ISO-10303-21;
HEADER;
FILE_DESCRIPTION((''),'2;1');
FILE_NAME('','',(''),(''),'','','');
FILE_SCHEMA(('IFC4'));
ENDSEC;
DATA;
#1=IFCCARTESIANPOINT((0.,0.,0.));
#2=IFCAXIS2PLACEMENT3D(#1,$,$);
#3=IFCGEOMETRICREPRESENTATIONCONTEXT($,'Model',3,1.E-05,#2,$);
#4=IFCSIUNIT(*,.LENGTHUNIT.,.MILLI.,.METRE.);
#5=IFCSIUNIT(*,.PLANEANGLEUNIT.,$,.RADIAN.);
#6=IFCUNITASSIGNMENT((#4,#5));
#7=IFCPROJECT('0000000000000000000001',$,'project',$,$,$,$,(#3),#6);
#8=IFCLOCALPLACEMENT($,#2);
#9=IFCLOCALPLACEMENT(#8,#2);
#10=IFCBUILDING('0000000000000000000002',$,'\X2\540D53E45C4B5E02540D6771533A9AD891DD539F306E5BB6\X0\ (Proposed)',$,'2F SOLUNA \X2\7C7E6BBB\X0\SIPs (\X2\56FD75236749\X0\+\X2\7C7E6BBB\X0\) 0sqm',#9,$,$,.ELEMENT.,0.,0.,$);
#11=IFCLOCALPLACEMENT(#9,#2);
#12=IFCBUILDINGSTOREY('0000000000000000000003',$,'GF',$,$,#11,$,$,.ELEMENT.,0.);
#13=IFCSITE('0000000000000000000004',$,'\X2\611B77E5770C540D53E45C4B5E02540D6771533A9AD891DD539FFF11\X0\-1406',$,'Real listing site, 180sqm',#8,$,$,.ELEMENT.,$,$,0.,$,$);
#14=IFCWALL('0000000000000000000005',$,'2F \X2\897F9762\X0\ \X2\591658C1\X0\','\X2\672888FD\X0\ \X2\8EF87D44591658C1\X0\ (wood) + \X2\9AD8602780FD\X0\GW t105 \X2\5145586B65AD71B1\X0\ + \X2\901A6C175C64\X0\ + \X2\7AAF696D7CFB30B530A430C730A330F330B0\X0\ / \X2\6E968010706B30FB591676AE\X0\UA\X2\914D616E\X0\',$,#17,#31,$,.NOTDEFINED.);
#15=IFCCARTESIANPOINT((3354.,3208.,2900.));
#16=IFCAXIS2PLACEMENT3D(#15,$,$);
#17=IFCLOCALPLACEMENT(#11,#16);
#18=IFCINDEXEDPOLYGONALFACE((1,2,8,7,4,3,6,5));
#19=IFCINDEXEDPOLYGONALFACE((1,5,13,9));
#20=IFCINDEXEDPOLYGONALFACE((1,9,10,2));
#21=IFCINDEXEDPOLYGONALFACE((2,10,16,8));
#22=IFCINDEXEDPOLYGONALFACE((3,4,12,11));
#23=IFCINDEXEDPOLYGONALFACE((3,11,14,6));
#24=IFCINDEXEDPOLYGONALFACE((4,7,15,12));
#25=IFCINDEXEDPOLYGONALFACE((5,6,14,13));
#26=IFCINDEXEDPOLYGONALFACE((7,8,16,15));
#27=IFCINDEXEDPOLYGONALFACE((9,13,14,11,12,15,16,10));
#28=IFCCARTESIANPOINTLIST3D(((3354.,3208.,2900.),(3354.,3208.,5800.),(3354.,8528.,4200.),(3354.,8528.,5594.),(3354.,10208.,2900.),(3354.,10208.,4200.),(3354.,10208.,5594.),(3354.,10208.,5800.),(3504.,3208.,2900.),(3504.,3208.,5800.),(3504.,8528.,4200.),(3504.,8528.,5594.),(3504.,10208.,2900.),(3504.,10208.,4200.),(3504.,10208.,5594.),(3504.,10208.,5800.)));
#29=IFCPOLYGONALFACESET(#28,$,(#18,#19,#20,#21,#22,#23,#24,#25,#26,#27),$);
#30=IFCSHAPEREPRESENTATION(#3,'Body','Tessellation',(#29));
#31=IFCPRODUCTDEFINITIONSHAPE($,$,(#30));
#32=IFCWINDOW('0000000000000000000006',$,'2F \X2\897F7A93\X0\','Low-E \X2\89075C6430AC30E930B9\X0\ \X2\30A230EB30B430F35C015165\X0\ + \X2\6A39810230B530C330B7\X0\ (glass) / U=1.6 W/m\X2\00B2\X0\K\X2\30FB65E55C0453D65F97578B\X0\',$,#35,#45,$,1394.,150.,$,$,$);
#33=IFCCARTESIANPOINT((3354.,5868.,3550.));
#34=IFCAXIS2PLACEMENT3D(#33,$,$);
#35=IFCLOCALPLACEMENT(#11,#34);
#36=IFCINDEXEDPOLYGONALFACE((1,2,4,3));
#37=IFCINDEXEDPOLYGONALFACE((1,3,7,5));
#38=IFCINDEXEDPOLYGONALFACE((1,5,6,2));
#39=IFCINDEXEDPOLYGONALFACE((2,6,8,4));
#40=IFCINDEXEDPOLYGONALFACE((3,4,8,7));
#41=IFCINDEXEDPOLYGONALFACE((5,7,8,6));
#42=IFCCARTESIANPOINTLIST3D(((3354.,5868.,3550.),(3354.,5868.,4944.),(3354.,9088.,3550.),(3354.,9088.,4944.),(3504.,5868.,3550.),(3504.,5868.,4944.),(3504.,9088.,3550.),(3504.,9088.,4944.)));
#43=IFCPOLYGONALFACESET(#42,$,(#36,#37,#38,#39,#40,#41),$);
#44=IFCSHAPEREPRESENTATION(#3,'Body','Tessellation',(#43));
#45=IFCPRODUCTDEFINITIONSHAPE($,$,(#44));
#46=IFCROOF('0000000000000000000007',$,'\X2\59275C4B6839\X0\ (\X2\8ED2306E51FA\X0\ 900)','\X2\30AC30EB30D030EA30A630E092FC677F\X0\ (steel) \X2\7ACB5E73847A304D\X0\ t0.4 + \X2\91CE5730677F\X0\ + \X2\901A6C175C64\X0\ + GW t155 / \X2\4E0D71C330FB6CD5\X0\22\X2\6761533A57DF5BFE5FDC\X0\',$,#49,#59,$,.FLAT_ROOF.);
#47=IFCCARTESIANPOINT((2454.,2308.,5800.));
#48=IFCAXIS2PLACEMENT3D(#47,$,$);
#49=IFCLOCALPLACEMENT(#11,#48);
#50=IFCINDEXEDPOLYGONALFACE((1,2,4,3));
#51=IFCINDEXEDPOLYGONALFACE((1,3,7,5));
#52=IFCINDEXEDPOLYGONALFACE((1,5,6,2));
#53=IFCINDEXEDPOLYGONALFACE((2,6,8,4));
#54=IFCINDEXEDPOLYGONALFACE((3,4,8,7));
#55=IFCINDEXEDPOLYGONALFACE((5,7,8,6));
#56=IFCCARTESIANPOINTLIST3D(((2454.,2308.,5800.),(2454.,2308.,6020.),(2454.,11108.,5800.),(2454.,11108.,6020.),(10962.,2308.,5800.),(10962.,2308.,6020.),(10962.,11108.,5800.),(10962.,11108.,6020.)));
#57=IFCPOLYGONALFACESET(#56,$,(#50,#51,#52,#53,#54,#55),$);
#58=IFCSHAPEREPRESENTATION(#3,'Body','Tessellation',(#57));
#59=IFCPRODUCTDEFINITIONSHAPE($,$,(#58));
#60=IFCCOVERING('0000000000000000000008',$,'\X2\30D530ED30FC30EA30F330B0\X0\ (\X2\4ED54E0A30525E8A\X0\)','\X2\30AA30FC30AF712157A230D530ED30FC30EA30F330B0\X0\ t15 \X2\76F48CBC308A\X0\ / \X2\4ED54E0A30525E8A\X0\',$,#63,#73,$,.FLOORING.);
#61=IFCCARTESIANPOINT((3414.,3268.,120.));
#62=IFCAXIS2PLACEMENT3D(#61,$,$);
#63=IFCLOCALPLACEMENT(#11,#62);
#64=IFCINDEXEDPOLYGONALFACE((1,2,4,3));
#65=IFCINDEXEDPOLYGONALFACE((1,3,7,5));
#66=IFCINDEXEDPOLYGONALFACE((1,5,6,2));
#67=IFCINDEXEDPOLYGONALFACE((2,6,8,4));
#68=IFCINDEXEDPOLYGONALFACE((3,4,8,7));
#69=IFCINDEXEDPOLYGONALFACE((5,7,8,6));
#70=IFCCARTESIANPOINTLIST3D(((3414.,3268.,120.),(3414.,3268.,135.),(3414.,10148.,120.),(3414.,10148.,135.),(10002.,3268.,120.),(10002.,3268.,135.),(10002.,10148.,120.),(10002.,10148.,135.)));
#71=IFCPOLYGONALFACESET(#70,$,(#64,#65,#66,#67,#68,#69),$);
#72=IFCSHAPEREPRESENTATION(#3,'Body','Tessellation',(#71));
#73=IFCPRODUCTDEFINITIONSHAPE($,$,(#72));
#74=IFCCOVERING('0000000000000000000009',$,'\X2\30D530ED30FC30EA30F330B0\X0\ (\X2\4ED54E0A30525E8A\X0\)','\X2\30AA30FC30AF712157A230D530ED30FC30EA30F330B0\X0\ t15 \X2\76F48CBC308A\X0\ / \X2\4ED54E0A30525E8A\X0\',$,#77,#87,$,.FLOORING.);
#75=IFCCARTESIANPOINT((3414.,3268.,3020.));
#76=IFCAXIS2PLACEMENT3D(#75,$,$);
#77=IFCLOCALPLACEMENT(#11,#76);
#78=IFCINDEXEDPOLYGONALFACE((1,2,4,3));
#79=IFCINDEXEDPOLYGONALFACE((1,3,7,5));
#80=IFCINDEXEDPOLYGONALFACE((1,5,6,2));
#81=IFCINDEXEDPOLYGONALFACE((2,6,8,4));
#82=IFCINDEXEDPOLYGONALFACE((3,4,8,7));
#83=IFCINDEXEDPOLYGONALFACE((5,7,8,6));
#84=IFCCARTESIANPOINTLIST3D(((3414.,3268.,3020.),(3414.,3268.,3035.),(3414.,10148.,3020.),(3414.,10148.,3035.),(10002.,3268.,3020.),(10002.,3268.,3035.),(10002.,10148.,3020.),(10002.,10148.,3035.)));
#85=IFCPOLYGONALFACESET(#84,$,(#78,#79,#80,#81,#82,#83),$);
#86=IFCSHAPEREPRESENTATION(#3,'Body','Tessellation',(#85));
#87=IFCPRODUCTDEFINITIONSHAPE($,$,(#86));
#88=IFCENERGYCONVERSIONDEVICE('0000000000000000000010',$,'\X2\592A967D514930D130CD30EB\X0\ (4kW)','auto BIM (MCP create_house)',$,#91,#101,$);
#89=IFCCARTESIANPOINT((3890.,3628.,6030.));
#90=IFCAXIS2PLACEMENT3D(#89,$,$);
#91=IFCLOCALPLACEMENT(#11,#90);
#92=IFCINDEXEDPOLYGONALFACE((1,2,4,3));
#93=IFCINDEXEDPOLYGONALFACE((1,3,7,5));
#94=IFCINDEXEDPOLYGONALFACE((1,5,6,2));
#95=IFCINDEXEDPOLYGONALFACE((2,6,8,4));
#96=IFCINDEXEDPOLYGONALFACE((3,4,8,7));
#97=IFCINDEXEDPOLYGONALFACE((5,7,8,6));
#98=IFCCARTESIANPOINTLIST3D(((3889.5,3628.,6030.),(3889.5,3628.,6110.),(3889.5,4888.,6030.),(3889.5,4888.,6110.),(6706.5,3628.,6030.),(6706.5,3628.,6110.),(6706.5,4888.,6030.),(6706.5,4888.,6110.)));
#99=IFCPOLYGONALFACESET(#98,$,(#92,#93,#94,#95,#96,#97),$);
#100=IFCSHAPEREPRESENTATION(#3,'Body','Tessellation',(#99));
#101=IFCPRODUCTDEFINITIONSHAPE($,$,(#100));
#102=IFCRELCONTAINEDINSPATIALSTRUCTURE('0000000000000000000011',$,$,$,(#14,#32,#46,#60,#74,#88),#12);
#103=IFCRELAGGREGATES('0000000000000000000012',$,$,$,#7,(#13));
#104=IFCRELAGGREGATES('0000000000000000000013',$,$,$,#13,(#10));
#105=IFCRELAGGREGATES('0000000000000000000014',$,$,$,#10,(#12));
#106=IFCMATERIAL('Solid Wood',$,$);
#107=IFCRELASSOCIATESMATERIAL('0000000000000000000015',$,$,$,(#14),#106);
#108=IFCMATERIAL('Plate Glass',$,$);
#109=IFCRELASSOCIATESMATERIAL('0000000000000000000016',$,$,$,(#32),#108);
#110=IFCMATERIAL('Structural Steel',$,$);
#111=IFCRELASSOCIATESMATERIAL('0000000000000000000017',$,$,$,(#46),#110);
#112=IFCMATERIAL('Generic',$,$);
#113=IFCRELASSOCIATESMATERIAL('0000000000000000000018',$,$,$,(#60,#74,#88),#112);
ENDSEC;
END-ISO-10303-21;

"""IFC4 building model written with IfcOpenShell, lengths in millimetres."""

from ifc_helpers import new_model, si_unit, frame, frame_2d, origin, place, context, project, spatial, rectangle, extrude, material, element, fill, save


model = new_model("IFC4")

# Units and contexts
model_context = context("Model", 3, precision=1e-05, world=origin())
ifc_project = project(units=[si_unit("LENGTHUNIT", "METRE", prefix="MILLI"), si_unit("PLANEANGLEUNIT", "RADIAN")], contexts=[model_context])

# Site, building, storey
site_placement = place(None, origin())
site = spatial("IfcSite", under=ifc_project, at=site_placement, Name="愛知県名古屋市名東区高針原１-1406", ObjectType="Real listing site, 180sqm", CompositionType="ELEMENT", RefElevation=0.0)
building_placement = place(site_placement, origin())
building = spatial("IfcBuilding", under=site, at=building_placement, Name="名古屋市名東区高針原の家 (Proposed)", ObjectType="2F SOLUNA 籾殻SIPs (国産杉+籾殻) 0sqm", CompositionType="ELEMENT", ElevationOfRefHeight=0.0, ElevationOfTerrain=0.0)
storey_placement = place(building_placement, origin())
storey = spatial("IfcBuildingStorey", under=building, at=storey_placement, Name="GF", CompositionType="ELEMENT", Elevation=0.0)

# Shared definitions
ifc_material_1 = material(Name="Solid Wood")

# Shared definitions
ifc_material_2 = material(Name="Plate Glass")

# Wall, opening, window
wall_1_placement = place(storey_placement, frame((3354.0, 3208.0, 2900.0)))
wall_1 = element("IfcWall", 1, at=wall_1_placement, inside=storey, material=ifc_material_1, Name="2F 西面 外壁", Description="木製 軸組外壁 (wood) + 高性能GW t105 充填断熱 + 通気層 + 窯業系サイディング / 準耐火・外皮UA配慮", PredefinedType="NOTDEFINED", context=model_context, shape_type="SweptSolid", body=[
    extrude(rectangle(XDim=150.0, YDim=7000.0, at=frame_2d((75.0, 3500.0))), frame((3354.0, 3208.0, 2900.0)), (0.0, 0.0, 1.0), 2900.0),
])
opening_1_placement = place(storey_placement, frame((3354.0, 5868.0, 3550.0)))
opening_1 = element("IfcOpeningElement", 2, at=opening_1_placement, cuts=wall_1, PredefinedType="NOTDEFINED", context=model_context, shape_type="SweptSolid", body=[
    extrude(rectangle(XDim=150.0, YDim=3220.0, at=frame_2d((75.0, 1610.0))), frame((3354.0, 5868.0, 3550.0)), (0.0, 0.0, 1.0), 1394.0),
])
window_1_placement = place(storey_placement, frame((3354.0, 5868.0, 3550.0)))
window_1 = element("IfcWindow", 3, at=window_1_placement, inside=storey, material=ifc_material_2, Name="2F 西窓", Description="Low-E 複層ガラス アルゴン封入 + 樹脂サッシ (glass) / U=1.6 W/m²K・日射取得型", OverallHeight=1394.0, OverallWidth=150.0, context=model_context, shape_type="SweptSolid", body=[
    extrude(rectangle(XDim=150.0, YDim=3220.0, at=frame_2d((75.0, 1610.0))), frame((3354.0, 5868.0, 3550.0)), (0.0, 0.0, 1.0), 1394.0),
])
fill(opening_1, window_1)

# Roof
ifc_material_3 = material(Name="Structural Steel")
roof_placement = place(storey_placement, frame((2454.0, 2308.0, 5800.0)))
element("IfcRoof", 4, at=roof_placement, inside=storey, material=ifc_material_3, Name="大屋根 (軒の出 900)", Description="ガルバリウム鋼板 (steel) 立平葺き t0.4 + 野地板 + 通気層 + GW t155 / 不燃・法22条区域対応", PredefinedType="FLAT_ROOF", context=model_context, shape_type="SweptSolid", body=[
    extrude(rectangle(XDim=8508.0, YDim=8800.0, at=frame_2d((4254.0, 4400.0))), frame((2454.0, 2308.0, 5800.0)), (0.0, 0.0, 1.0), 220.0),
])

# Coverings
ifc_material_4 = material(Name="Generic")
covering_1_placement = place(storey_placement, frame((3414.0, 3268.0, 120.0)))
element("IfcCovering", 5, at=covering_1_placement, inside=storey, material=ifc_material_4, Name="フローリング (仕上げ床)", Description="オーク無垢フローリング t15 直貼り / 仕上げ床", PredefinedType="FLOORING", context=model_context, shape_type="SweptSolid", body=[
    extrude(rectangle(XDim=6588.0, YDim=6880.0, at=frame_2d((3294.0, 3440.0))), frame((3414.0, 3268.0, 120.0)), (0.0, 0.0, 1.0), 15.0),
])
covering_2_placement = place(storey_placement, frame((3414.0, 3268.0, 3020.0)))
element("IfcCovering", 6, at=covering_2_placement, inside=storey, material=ifc_material_4, Name="フローリング (仕上げ床)", Description="オーク無垢フローリング t15 直貼り / 仕上げ床", PredefinedType="FLOORING", context=model_context, shape_type="SweptSolid", body=[
    extrude(rectangle(XDim=6588.0, YDim=6880.0, at=frame_2d((3294.0, 3440.0))), frame((3414.0, 3268.0, 3020.0)), (0.0, 0.0, 1.0), 15.0),
])

# Energy conversion device
energy_conversion_device_placement = place(storey_placement, frame((3890.0, 3628.0, 6030.0)))
element("IfcEnergyConversionDevice", 7, at=energy_conversion_device_placement, inside=storey, material=ifc_material_4, Name="太陽光パネル (4kW)", Description="auto BIM (MCP create_house)", context=model_context, shape_type="SweptSolid", body=[
    extrude(rectangle(XDim=2817.0, YDim=1260.0, at=frame_2d((1408.0, 630.0))), frame((3890.0, 3628.0, 6030.0)), (0.0, 0.0, 1.0), 80.0),
])

save(model, "model.ifc")
